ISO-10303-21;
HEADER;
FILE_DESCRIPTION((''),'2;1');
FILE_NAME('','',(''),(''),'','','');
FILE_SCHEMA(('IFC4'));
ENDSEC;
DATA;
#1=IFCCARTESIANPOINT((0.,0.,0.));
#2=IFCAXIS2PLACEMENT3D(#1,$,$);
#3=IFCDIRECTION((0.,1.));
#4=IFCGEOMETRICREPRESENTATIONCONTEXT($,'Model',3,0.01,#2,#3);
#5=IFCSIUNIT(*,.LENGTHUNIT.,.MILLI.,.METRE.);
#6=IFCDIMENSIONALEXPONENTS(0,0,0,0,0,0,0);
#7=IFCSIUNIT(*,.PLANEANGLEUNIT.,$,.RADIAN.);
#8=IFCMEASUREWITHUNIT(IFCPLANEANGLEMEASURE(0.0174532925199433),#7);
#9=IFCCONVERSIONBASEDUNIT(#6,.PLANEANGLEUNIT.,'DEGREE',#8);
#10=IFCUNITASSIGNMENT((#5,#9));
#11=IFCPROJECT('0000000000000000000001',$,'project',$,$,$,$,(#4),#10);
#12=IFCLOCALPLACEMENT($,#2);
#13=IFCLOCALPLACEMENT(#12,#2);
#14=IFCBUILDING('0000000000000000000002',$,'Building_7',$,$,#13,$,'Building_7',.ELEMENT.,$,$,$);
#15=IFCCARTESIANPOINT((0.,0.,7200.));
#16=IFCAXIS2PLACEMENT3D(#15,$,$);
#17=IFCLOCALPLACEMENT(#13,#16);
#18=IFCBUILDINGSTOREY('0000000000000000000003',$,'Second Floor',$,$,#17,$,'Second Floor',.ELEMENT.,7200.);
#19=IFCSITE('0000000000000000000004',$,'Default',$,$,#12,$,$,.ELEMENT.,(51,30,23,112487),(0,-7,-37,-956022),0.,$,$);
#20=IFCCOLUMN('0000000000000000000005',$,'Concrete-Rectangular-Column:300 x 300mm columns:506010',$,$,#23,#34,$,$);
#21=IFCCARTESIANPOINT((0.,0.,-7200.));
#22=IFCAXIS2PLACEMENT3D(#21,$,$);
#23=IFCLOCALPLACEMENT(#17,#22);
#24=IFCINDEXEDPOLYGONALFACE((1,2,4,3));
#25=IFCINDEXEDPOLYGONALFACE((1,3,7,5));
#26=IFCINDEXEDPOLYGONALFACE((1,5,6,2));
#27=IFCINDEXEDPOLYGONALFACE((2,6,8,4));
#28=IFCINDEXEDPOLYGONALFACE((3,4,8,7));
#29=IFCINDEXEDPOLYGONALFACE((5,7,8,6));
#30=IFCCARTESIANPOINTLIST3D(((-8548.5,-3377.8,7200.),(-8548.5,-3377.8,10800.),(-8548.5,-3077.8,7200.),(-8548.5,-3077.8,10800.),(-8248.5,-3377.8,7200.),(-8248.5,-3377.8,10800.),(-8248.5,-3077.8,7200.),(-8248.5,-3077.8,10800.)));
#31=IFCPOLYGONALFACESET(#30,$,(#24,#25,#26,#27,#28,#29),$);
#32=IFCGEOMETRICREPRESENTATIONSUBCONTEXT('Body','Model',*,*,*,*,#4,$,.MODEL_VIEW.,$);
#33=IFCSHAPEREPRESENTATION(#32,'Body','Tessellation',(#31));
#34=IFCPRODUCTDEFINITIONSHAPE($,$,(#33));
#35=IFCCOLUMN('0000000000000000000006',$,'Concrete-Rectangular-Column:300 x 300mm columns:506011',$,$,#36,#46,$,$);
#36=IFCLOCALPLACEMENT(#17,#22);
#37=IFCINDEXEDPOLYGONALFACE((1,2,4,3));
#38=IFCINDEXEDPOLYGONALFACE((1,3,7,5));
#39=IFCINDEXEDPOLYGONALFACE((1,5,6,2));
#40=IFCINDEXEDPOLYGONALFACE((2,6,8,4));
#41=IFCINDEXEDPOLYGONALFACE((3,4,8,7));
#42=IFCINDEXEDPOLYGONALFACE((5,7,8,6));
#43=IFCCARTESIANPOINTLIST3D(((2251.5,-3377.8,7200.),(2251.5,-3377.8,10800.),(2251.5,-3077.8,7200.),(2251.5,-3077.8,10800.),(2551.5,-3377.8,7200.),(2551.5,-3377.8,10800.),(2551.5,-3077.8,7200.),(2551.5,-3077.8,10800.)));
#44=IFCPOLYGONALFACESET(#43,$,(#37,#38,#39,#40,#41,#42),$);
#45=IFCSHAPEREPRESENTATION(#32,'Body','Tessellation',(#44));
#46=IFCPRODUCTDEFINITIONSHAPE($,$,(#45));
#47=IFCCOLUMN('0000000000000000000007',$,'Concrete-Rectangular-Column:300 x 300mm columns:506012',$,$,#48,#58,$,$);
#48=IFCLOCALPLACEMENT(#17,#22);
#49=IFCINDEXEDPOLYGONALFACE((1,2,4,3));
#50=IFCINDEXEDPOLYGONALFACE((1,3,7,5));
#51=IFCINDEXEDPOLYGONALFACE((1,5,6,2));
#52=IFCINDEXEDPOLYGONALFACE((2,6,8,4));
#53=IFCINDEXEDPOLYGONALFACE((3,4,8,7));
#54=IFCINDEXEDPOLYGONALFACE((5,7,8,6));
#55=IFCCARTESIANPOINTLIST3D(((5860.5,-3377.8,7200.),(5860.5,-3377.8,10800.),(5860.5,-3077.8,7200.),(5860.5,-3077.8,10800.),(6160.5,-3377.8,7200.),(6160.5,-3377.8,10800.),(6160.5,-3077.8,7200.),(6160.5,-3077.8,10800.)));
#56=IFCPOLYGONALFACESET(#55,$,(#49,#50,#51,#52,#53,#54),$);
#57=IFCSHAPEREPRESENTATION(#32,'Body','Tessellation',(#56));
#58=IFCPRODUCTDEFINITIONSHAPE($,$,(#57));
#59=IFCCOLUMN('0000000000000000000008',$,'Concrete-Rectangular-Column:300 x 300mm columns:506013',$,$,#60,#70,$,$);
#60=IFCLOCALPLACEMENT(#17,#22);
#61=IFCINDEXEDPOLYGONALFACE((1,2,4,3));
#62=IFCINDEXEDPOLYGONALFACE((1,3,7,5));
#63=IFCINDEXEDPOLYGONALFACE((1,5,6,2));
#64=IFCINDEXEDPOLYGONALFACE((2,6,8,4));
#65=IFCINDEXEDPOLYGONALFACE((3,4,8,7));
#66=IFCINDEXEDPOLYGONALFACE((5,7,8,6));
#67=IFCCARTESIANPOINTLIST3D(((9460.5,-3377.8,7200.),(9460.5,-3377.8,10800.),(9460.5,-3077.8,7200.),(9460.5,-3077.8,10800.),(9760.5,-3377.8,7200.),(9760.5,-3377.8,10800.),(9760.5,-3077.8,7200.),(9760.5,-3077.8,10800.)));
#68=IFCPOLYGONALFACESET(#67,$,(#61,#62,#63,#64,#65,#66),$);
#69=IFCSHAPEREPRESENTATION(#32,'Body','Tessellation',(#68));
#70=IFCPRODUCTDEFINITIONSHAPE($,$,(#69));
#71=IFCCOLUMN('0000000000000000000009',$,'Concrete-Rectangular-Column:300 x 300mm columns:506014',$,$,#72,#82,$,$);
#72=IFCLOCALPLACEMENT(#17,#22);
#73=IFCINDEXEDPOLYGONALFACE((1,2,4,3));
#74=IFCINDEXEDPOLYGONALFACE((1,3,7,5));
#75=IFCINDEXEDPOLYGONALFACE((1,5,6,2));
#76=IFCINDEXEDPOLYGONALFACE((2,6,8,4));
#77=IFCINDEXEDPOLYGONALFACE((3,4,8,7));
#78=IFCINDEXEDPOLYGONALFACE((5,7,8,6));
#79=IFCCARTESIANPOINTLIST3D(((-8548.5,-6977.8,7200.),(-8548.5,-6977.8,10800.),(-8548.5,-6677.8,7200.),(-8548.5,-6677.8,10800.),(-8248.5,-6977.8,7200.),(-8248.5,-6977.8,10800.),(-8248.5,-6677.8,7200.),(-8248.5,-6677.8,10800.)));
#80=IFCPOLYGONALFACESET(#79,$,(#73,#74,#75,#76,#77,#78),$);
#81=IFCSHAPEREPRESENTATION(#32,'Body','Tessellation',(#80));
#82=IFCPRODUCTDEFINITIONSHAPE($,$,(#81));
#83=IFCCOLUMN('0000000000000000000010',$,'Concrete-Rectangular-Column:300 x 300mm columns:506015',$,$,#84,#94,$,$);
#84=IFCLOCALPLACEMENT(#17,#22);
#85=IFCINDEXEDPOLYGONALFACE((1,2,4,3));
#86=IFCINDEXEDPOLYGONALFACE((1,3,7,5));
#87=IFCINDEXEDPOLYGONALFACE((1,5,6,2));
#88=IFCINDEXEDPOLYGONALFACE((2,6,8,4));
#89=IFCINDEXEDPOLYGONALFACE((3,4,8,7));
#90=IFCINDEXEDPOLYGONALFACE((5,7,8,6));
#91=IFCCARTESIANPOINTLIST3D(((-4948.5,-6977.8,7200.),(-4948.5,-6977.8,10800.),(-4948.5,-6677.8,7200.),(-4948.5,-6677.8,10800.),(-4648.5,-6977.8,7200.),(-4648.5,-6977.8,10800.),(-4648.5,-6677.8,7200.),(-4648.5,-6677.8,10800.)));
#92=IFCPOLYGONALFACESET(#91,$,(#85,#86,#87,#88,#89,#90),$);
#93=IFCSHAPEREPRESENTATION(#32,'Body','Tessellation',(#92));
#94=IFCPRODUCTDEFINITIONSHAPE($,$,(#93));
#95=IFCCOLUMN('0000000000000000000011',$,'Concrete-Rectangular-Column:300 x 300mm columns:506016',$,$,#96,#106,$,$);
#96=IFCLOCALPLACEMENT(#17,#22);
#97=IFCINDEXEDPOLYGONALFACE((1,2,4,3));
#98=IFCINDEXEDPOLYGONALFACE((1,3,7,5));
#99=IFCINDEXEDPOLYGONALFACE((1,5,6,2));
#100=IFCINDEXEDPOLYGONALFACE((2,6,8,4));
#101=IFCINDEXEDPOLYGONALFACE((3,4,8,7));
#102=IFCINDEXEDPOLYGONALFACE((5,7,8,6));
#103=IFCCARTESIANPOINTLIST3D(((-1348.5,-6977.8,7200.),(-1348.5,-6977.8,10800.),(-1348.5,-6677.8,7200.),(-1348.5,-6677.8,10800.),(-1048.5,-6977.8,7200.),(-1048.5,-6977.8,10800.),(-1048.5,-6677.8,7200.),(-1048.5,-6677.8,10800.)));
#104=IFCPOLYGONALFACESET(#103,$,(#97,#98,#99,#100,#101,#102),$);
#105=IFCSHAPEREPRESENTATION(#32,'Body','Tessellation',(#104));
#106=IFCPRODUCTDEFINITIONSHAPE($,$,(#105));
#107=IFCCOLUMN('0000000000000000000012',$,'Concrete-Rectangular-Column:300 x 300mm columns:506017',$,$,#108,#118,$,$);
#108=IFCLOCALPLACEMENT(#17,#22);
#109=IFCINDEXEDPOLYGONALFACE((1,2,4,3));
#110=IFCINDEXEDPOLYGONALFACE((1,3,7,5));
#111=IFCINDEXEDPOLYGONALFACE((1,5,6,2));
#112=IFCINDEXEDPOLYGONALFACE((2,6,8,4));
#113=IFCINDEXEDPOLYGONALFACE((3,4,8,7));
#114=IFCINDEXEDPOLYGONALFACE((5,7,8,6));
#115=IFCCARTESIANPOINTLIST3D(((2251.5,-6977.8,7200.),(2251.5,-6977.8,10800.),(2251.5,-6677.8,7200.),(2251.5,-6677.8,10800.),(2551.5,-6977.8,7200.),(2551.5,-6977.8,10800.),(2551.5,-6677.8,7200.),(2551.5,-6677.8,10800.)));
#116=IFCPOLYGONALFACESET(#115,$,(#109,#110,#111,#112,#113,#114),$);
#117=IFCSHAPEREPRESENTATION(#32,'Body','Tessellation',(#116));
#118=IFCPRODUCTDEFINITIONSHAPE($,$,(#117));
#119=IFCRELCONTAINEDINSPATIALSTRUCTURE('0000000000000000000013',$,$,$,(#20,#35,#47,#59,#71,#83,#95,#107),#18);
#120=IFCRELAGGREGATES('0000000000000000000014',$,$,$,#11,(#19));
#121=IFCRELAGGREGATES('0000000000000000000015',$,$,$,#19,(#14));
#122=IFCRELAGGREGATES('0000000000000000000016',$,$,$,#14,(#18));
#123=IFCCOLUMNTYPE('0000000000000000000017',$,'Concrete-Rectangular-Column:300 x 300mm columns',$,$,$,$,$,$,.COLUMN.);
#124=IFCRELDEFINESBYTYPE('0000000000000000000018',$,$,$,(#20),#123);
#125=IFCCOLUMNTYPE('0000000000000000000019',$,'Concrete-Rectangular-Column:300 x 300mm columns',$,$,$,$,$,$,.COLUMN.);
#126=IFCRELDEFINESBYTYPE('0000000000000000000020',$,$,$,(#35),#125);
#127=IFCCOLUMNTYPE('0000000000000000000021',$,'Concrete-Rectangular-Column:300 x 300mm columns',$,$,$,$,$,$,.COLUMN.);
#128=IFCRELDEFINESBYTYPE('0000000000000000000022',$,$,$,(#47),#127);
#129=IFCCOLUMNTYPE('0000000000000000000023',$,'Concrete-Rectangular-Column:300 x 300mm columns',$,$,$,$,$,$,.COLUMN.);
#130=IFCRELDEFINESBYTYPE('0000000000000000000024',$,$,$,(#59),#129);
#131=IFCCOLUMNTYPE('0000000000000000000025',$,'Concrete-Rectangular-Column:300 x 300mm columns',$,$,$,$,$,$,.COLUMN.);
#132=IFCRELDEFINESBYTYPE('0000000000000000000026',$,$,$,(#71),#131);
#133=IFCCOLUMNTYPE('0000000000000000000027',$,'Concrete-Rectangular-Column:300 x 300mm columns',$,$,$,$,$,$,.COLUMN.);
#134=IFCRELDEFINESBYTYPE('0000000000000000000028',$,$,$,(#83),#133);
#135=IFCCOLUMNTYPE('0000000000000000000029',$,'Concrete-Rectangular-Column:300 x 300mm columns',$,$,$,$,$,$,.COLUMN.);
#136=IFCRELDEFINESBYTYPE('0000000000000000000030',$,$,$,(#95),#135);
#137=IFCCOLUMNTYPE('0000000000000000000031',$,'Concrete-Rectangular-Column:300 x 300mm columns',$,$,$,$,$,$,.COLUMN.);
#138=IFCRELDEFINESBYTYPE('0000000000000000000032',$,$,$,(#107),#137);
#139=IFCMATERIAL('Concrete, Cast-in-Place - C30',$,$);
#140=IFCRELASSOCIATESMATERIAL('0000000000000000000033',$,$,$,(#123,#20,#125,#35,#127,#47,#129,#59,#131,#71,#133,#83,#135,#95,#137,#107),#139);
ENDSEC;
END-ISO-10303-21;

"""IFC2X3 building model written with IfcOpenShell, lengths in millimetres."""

from ifc_helpers import new_model, entity, si_unit, converted_unit, direction, frame, frame_2d, origin, origin_2d_with_axis, place, context, subcontext, project, spatial, rectangle, extrude, source, transform, mapped, material, type_object, type_shapes, element, save


model = new_model("IFC2X3")

# Units and contexts
model_context = context("Model", 3, precision=0.01, world=origin(), true_north=direction((0.0, 1.0)))
body_context = subcontext(model_context, "Body", "Model", "MODEL_VIEW")
ifc_project = project(units=[si_unit("LENGTHUNIT", "METRE", prefix="MILLI"), converted_unit("PLANEANGLEUNIT", "DEGREE", entity("IfcPlaneAngleMeasure", 0.0174532925199433), si_unit("PLANEANGLEUNIT", "RADIAN"), dimensions=[0, 0, 0, 0, 0, 0, 0])], contexts=[model_context])

# Site, building, storey
site_placement = place(None, origin())
site = spatial("IfcSite", under=ifc_project, at=site_placement, Name="Default", CompositionType="ELEMENT", RefLatitude=(51, 30, 23, 112487), RefLongitude=(0, -7, -37, -956022), RefElevation=0.0)
building_placement = place(site_placement, origin())
building = spatial("IfcBuilding", under=site, at=building_placement, Name="Building_7", LongName="Building_7", CompositionType="ELEMENT")
storey_placement = place(building_placement, frame((0.0, 0.0, 7200.0)))
storey = spatial("IfcBuildingStorey", under=building, at=storey_placement, Name="Second Floor", LongName="Second Floor", CompositionType="ELEMENT", Elevation=7200.0)

# Columns
ifc_material_1 = material(Name="Concrete, Cast-in-Place - C30")
column_type_1 = type_object("IfcColumnType", Name="Concrete-Rectangular-Column:300 x 300mm columns", PredefinedType="COLUMN", material=ifc_material_1)
shared_shape_1 = source(origin(), body_context, "Body", "SweptSolid", [
    extrude(rectangle(XDim=300.0, YDim=300.0, at=frame_2d((0.0, 0.0), x_axis=(1.0, 0.0))), frame((-8398.5, -3227.8, 7200.0), z_axis=(0.0, 0.0, 1.0), x_axis=(-1.0, 0.0, 0.0)), (0.0, 0.0, 1.0), 3600.0),
])
type_shapes(column_type_1, [shared_shape_1])
column_1_placement = place(storey_placement, frame((0.0, 0.0, -7200.0)))
element("IfcColumn", 1, at=column_1_placement, inside=storey, type_object=column_type_1, material=ifc_material_1, Name="Concrete-Rectangular-Column:300 x 300mm columns:506010", context=body_context, shape_type="MappedRepresentation", body=[
    mapped(shared_shape_1, transform((0.0, 0.0, 0.0), scale=1.0)),
])
column_type_2 = type_object("IfcColumnType", Name="Concrete-Rectangular-Column:300 x 300mm columns", PredefinedType="COLUMN", material=ifc_material_1)
shared_shape_2 = source(origin(), body_context, "Body", "SweptSolid", [
    extrude(rectangle(XDim=300.0, YDim=300.0, at=origin_2d_with_axis()), frame((2401.5, -3227.8, 7200.0), z_axis=(0.0, 0.0, 1.0), x_axis=(-1.0, 0.0, 0.0)), (0.0, 0.0, 1.0), 3600.0),
])
type_shapes(column_type_2, [shared_shape_2])
column_2_placement = place(storey_placement, frame((0.0, 0.0, -7200.0)))
element("IfcColumn", 2, at=column_2_placement, inside=storey, type_object=column_type_2, material=ifc_material_1, Name="Concrete-Rectangular-Column:300 x 300mm columns:506011", context=body_context, shape_type="MappedRepresentation", body=[
    mapped(shared_shape_2, transform((0.0, 0.0, 0.0), scale=1.0)),
])
column_type_3 = type_object("IfcColumnType", Name="Concrete-Rectangular-Column:300 x 300mm columns", PredefinedType="COLUMN", material=ifc_material_1)
shared_shape_3 = source(origin(), body_context, "Body", "SweptSolid", [
    extrude(rectangle(XDim=300.0, YDim=300.0, at=frame_2d((0.0, 0.0), x_axis=(1.0, 0.0))), frame((6010.5, -3227.8, 7200.0), z_axis=(0.0, 0.0, 1.0), x_axis=(-1.0, 0.0, 0.0)), (0.0, 0.0, 1.0), 3600.0),
])
type_shapes(column_type_3, [shared_shape_3])
column_3_placement = place(storey_placement, frame((0.0, 0.0, -7200.0)))
element("IfcColumn", 3, at=column_3_placement, inside=storey, type_object=column_type_3, material=ifc_material_1, Name="Concrete-Rectangular-Column:300 x 300mm columns:506012", context=body_context, shape_type="MappedRepresentation", body=[
    mapped(shared_shape_3, transform((0.0, 0.0, 0.0), scale=1.0)),
])
column_type_4 = type_object("IfcColumnType", Name="Concrete-Rectangular-Column:300 x 300mm columns", PredefinedType="COLUMN", material=ifc_material_1)
shared_shape_4 = source(origin(), body_context, "Body", "SweptSolid", [
    extrude(rectangle(XDim=300.0, YDim=300.0, at=frame_2d((0.0, 0.0), x_axis=(1.0, 0.0))), frame((9610.5, -3227.8, 7200.0), z_axis=(0.0, 0.0, 1.0), x_axis=(-1.0, 0.0, 0.0)), (0.0, 0.0, 1.0), 3600.0),
])
type_shapes(column_type_4, [shared_shape_4])
column_4_placement = place(storey_placement, frame((0.0, 0.0, -7200.0)))
element("IfcColumn", 4, at=column_4_placement, inside=storey, type_object=column_type_4, material=ifc_material_1, Name="Concrete-Rectangular-Column:300 x 300mm columns:506013", context=body_context, shape_type="MappedRepresentation", body=[
    mapped(shared_shape_4, transform((0.0, 0.0, 0.0), scale=1.0)),
])
column_type_5 = type_object("IfcColumnType", Name="Concrete-Rectangular-Column:300 x 300mm columns", PredefinedType="COLUMN", material=ifc_material_1)
shared_shape_5 = source(origin(), body_context, "Body", "SweptSolid", [
    extrude(rectangle(XDim=300.0, YDim=300.0, at=frame_2d((0.0, 0.0), x_axis=(1.0, 0.0))), frame((-8398.5, -6827.8, 7200.0), z_axis=(0.0, 0.0, 1.0), x_axis=(-1.0, 0.0, 0.0)), (0.0, 0.0, 1.0), 3600.0),
])
type_shapes(column_type_5, [shared_shape_5])
column_5_placement = place(storey_placement, frame((0.0, 0.0, -7200.0)))
element("IfcColumn", 5, at=column_5_placement, inside=storey, type_object=column_type_5, material=ifc_material_1, Name="Concrete-Rectangular-Column:300 x 300mm columns:506014", context=body_context, shape_type="MappedRepresentation", body=[
    mapped(shared_shape_5, transform((0.0, 0.0, 0.0), scale=1.0)),
])
column_type_6 = type_object("IfcColumnType", Name="Concrete-Rectangular-Column:300 x 300mm columns", PredefinedType="COLUMN", material=ifc_material_1)
shared_shape_6 = source(origin(), body_context, "Body", "SweptSolid", [
    extrude(rectangle(XDim=300.0, YDim=300.0, at=frame_2d((0.0, 0.0), x_axis=(1.0, 0.0))), frame((-4798.5, -6827.8, 7200.0), z_axis=(0.0, 0.0, 1.0), x_axis=(-1.0, 0.0, 0.0)), (0.0, 0.0, 1.0), 3600.0),
])
type_shapes(column_type_6, [shared_shape_6])
column_6_placement = place(storey_placement, frame((0.0, 0.0, -7200.0)))
element("IfcColumn", 6, at=column_6_placement, inside=storey, type_object=column_type_6, material=ifc_material_1, Name="Concrete-Rectangular-Column:300 x 300mm columns:506015", context=body_context, shape_type="MappedRepresentation", body=[
    mapped(shared_shape_6, transform((0.0, 0.0, 0.0), scale=1.0)),
])
column_type_7 = type_object("IfcColumnType", Name="Concrete-Rectangular-Column:300 x 300mm columns", PredefinedType="COLUMN", material=ifc_material_1)
shared_shape_7 = source(origin(), body_context, "Body", "SweptSolid", [
    extrude(rectangle(XDim=300.0, YDim=300.0, at=frame_2d((0.0, 0.0), x_axis=(1.0, 0.0))), frame((-1198.5, -6827.8, 7200.0), z_axis=(0.0, 0.0, 1.0), x_axis=(-1.0, 0.0, 0.0)), (0.0, 0.0, 1.0), 3600.0),
])
type_shapes(column_type_7, [shared_shape_7])
column_7_placement = place(storey_placement, frame((0.0, 0.0, -7200.0)))
element("IfcColumn", 7, at=column_7_placement, inside=storey, type_object=column_type_7, material=ifc_material_1, Name="Concrete-Rectangular-Column:300 x 300mm columns:506016", context=body_context, shape_type="MappedRepresentation", body=[
    mapped(shared_shape_7, transform((0.0, 0.0, 0.0), scale=1.0)),
])
column_type_8 = type_object("IfcColumnType", Name="Concrete-Rectangular-Column:300 x 300mm columns", PredefinedType="COLUMN", material=ifc_material_1)
shared_shape_8 = source(origin(), body_context, "Body", "SweptSolid", [
    extrude(rectangle(XDim=300.0, YDim=300.0, at=frame_2d((0.0, 0.0), x_axis=(1.0, 0.0))), frame((2401.5, -6827.8, 7200.0), z_axis=(0.0, 0.0, 1.0), x_axis=(-1.0, 0.0, 0.0)), (0.0, 0.0, 1.0), 3600.0),
])
type_shapes(column_type_8, [shared_shape_8])
column_8_placement = place(storey_placement, frame((0.0, 0.0, -7200.0)))
element("IfcColumn", 8, at=column_8_placement, inside=storey, type_object=column_type_8, material=ifc_material_1, Name="Concrete-Rectangular-Column:300 x 300mm columns:506017", context=body_context, shape_type="MappedRepresentation", body=[
    mapped(shared_shape_8, transform((0.0, 0.0, 0.0), scale=1.0)),
])

save(model, "model.ifc")
